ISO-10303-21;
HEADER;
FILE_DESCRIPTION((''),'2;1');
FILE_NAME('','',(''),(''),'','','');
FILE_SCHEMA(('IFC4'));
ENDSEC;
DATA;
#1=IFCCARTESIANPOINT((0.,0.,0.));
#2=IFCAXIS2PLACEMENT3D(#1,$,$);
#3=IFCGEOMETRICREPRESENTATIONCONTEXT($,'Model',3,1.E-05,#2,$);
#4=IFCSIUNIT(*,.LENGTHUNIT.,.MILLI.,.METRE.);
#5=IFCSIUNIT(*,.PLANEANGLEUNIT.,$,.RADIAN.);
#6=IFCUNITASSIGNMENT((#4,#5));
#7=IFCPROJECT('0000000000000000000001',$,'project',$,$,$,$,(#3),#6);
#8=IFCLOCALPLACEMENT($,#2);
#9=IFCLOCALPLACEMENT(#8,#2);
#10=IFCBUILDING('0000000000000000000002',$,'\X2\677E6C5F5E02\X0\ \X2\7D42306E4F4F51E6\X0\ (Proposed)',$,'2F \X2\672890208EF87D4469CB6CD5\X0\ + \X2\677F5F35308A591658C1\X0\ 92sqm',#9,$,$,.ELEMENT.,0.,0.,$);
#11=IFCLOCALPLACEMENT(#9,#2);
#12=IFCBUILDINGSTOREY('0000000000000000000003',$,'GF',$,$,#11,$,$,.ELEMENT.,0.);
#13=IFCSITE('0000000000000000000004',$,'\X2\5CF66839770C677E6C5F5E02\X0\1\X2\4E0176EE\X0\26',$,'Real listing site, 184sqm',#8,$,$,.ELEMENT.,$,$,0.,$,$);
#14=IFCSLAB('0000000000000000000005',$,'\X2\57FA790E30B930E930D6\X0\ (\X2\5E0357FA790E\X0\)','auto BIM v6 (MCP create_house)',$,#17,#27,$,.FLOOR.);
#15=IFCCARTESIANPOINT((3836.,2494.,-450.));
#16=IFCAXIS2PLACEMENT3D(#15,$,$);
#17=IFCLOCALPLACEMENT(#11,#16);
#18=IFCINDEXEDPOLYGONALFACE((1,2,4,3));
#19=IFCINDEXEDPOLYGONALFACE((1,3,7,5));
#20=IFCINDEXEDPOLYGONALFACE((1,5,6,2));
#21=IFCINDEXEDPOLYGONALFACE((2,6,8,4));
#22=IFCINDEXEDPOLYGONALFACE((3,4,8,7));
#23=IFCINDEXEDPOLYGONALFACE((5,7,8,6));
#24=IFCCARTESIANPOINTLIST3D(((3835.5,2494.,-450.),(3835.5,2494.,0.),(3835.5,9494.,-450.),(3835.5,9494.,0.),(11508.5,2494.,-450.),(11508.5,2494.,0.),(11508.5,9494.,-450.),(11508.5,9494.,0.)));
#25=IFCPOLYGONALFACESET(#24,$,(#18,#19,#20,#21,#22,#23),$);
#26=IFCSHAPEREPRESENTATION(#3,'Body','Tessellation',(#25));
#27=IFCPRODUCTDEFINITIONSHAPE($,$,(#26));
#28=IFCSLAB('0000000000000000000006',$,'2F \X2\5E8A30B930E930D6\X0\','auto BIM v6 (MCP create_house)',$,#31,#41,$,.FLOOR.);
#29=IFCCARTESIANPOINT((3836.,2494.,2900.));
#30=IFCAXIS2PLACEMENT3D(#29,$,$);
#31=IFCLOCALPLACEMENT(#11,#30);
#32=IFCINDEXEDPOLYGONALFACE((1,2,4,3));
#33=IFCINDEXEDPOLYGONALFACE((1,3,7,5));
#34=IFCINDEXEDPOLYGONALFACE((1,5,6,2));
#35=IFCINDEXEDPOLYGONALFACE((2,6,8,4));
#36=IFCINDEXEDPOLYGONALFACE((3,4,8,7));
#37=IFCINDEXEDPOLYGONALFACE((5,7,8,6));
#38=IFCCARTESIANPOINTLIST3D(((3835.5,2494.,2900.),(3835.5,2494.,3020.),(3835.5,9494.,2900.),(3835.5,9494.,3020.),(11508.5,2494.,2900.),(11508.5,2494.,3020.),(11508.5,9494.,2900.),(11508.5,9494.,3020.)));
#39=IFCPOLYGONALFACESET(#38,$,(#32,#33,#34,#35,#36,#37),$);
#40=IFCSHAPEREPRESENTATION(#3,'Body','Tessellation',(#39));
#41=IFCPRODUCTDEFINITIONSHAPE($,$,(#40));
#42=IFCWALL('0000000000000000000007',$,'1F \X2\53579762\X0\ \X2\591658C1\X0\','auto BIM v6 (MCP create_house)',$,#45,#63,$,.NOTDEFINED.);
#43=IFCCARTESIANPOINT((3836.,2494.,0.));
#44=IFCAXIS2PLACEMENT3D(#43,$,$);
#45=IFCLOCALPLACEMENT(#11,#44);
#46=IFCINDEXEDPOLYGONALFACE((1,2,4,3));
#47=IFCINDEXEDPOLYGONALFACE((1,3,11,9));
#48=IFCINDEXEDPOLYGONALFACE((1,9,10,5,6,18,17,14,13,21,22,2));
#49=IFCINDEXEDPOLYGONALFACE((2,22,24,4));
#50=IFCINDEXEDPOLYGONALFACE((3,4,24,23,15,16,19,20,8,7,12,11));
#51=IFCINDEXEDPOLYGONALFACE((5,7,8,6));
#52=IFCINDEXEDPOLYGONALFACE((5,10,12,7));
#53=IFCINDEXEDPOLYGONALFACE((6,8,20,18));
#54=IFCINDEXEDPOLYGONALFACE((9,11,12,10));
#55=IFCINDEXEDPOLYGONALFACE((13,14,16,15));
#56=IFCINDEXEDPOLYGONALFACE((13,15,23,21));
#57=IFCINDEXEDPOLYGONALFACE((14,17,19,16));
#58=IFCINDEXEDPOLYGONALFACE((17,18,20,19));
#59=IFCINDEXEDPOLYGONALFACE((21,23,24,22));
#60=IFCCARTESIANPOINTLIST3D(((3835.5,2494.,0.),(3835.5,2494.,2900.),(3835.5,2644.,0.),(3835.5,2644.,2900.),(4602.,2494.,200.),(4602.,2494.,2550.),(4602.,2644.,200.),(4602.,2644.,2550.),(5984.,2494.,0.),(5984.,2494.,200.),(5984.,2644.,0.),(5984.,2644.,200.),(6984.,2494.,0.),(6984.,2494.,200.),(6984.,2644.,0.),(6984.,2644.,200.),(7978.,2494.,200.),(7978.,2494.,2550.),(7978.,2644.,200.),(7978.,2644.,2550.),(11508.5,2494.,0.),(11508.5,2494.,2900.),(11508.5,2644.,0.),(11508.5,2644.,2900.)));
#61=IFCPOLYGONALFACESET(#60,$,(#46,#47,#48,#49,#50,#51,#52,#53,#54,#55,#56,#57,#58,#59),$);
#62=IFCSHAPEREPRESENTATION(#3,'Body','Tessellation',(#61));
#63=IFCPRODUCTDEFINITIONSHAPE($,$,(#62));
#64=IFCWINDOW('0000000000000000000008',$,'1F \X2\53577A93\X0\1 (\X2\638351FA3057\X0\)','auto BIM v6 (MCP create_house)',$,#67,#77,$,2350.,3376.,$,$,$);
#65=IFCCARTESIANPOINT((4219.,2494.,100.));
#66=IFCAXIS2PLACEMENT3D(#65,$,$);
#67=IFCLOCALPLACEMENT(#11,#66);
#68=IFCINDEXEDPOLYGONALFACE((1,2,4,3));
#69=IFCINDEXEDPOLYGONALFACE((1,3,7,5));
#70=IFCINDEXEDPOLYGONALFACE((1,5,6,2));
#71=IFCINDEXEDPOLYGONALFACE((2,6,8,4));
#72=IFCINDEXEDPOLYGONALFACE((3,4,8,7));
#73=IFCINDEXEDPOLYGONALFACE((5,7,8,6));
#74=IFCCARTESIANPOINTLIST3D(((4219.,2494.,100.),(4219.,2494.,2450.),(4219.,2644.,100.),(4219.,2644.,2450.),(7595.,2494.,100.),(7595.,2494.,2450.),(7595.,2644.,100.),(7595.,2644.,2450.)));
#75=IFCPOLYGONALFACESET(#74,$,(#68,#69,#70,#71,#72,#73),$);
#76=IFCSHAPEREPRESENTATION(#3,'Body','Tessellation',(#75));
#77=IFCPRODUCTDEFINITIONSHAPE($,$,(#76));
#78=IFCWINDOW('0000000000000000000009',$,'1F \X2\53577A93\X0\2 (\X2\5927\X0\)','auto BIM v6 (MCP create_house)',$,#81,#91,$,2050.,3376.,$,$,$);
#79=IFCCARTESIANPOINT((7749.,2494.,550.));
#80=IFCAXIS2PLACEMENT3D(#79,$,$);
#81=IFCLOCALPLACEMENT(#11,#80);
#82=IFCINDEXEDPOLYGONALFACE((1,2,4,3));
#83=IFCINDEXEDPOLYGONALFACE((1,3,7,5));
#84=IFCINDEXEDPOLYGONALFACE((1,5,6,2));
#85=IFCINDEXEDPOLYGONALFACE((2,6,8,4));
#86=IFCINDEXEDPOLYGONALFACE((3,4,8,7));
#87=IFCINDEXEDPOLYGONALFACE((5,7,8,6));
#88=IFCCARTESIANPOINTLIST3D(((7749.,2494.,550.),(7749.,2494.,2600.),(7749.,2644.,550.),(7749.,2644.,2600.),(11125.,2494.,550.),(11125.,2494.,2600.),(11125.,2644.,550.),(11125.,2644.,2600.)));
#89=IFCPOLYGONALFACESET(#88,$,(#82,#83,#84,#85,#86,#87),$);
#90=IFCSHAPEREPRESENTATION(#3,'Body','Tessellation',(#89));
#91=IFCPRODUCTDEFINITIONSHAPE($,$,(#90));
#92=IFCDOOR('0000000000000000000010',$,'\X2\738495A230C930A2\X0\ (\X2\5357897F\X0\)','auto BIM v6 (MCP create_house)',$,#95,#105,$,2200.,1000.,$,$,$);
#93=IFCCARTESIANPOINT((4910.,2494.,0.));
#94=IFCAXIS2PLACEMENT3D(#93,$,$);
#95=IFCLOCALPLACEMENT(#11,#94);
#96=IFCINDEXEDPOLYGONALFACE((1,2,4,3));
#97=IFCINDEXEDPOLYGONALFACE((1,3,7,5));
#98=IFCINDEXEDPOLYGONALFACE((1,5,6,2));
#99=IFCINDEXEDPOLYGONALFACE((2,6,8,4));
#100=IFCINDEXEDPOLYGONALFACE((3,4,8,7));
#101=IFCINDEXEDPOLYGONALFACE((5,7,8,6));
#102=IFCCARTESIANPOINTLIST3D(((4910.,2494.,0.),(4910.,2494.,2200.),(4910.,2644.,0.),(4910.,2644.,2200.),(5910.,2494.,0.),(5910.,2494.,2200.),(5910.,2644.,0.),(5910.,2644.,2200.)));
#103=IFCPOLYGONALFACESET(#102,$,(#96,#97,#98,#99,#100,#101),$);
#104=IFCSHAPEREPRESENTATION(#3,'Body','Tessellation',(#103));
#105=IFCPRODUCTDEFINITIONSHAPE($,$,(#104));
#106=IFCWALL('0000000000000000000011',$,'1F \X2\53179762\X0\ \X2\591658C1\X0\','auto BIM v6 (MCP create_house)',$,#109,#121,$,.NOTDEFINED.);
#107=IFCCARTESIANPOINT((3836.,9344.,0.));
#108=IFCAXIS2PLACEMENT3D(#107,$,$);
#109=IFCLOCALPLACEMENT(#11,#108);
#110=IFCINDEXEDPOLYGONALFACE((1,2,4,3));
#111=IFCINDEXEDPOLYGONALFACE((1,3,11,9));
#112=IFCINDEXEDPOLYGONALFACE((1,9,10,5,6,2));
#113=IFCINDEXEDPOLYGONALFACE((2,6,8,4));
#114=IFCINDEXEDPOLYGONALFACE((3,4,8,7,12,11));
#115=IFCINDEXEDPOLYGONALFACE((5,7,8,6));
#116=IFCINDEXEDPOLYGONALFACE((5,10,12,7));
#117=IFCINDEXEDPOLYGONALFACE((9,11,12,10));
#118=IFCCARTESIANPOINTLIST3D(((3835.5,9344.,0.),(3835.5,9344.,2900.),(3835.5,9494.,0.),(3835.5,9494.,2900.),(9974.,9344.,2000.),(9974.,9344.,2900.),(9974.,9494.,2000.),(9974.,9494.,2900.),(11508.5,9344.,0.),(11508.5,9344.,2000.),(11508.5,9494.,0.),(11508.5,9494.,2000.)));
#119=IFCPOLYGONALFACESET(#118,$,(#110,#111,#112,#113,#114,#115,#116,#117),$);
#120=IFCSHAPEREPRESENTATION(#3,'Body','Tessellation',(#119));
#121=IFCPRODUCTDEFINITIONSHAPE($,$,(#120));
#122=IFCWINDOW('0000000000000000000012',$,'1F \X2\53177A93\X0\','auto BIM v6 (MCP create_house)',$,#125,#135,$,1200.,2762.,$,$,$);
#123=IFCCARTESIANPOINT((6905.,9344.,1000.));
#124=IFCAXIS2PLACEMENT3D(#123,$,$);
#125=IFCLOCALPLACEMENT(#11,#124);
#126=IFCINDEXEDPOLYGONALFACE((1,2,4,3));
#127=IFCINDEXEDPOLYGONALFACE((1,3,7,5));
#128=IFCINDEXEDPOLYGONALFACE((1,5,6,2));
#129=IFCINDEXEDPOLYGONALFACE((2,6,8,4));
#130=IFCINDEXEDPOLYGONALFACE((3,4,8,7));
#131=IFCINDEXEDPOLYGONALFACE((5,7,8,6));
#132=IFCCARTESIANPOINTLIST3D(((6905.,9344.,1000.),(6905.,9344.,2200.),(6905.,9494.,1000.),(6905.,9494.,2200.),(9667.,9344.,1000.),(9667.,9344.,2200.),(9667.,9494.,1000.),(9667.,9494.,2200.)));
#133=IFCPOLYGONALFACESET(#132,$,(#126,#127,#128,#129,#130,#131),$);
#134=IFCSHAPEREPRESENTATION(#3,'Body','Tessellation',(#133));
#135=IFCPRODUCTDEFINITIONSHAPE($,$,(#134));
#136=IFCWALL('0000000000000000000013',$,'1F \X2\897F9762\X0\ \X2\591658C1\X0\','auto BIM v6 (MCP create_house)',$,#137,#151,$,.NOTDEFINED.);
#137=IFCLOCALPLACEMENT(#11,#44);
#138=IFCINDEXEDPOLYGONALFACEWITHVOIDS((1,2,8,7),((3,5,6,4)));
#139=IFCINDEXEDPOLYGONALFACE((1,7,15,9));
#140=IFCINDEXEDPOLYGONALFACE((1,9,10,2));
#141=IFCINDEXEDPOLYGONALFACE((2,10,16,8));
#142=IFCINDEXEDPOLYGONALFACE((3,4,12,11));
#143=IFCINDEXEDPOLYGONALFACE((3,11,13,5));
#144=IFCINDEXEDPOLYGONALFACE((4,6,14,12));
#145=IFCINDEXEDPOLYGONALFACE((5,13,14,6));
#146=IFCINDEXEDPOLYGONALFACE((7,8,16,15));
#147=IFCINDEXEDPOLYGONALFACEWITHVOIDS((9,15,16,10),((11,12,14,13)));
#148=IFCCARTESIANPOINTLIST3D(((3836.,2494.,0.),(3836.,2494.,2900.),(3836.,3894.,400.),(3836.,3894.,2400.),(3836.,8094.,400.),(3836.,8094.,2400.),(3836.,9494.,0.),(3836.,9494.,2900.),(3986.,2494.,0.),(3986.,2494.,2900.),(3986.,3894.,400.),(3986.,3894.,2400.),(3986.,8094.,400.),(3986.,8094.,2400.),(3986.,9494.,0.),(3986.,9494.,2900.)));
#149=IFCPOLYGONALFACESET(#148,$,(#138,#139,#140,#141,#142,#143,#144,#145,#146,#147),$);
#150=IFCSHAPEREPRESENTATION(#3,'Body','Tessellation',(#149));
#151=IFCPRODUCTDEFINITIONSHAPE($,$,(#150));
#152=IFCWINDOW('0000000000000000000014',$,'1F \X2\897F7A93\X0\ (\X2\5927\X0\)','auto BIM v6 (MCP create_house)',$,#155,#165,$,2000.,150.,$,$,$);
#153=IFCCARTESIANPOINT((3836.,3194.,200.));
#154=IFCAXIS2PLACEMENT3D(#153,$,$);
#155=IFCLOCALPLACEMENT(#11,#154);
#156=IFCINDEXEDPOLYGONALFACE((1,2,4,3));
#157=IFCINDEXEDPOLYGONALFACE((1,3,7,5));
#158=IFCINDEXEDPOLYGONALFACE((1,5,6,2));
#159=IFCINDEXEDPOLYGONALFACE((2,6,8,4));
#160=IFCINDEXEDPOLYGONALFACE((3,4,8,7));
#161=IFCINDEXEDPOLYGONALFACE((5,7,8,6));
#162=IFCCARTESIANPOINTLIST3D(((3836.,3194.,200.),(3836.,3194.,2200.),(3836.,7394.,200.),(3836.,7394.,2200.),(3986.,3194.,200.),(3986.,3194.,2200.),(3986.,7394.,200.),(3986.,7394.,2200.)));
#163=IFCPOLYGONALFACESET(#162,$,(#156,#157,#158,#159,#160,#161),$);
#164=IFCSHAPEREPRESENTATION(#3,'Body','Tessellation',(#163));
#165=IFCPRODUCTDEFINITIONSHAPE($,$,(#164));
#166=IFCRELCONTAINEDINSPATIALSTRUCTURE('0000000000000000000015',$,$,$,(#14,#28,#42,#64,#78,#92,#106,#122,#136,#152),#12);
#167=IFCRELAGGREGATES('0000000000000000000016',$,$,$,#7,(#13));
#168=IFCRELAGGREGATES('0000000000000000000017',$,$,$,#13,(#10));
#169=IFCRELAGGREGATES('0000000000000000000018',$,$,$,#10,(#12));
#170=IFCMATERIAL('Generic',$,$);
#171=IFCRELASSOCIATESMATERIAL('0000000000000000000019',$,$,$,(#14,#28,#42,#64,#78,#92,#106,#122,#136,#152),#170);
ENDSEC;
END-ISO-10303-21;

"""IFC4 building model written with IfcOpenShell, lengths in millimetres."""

from ifc_helpers import new_model, si_unit, frame, frame_2d, origin, place, context, project, spatial, rectangle, extrude, material, element, fill, save


model = new_model("IFC4")

# Units and contexts
model_context = context("Model", 3, precision=1e-05, world=origin())
ifc_project = project(units=[si_unit("LENGTHUNIT", "METRE", prefix="MILLI"), si_unit("PLANEANGLEUNIT", "RADIAN")], contexts=[model_context])

# Site, building, storey
site_placement = place(None, origin())
site = spatial("IfcSite", under=ifc_project, at=site_placement, Name="島根県松江市1丁目26", ObjectType="Real listing site, 184sqm", CompositionType="ELEMENT", RefElevation=0.0)
building_placement = place(site_placement, origin())
building = spatial("IfcBuilding", under=site, at=building_placement, Name="松江市 終の住処 (Proposed)", ObjectType="2F 木造軸組構法 + 板張り外壁 92sqm", CompositionType="ELEMENT", ElevationOfRefHeight=0.0, ElevationOfTerrain=0.0)
storey_placement = place(building_placement, origin())
storey = spatial("IfcBuildingStorey", under=building, at=storey_placement, Name="GF", CompositionType="ELEMENT", Elevation=0.0)

# Slabs
ifc_material = material(Name="Generic")
slab_1_placement = place(storey_placement, frame((3836.0, 2494.0, -450.0)))
element("IfcSlab", 1, at=slab_1_placement, inside=storey, material=ifc_material, Name="基礎スラブ (布基礎)", Description="auto BIM v6 (MCP create_house)", PredefinedType="FLOOR", context=model_context, shape_type="SweptSolid", body=[
    extrude(rectangle(XDim=7673.0, YDim=7000.0, at=frame_2d((3836.0, 3500.0))), frame((3836.0, 2494.0, -450.0)), (0.0, 0.0, 1.0), 450.0),
])
slab_2_placement = place(storey_placement, frame((3836.0, 2494.0, 2900.0)))
element("IfcSlab", 2, at=slab_2_placement, inside=storey, material=ifc_material, Name="2F 床スラブ", Description="auto BIM v6 (MCP create_house)", PredefinedType="FLOOR", context=model_context, shape_type="SweptSolid", body=[
    extrude(rectangle(XDim=7673.0, YDim=7000.0, at=frame_2d((3836.0, 3500.0))), frame((3836.0, 2494.0, 2900.0)), (0.0, 0.0, 1.0), 120.0),
])

# Wall, openings, windows, door
wall_1_placement = place(storey_placement, frame((3836.0, 2494.0, 0.0)))
wall_1 = element("IfcWall", 3, at=wall_1_placement, inside=storey, material=ifc_material, Name="1F 南面 外壁", Description="auto BIM v6 (MCP create_house)", PredefinedType="NOTDEFINED", context=model_context, shape_type="SweptSolid", body=[
    extrude(rectangle(XDim=7673.0, YDim=150.0, at=frame_2d((3836.0, 75.0))), frame((3836.0, 2494.0, 0.0)), (0.0, 0.0, 1.0), 2900.0),
])
opening_1_placement = place(storey_placement, frame((4219.0, 2494.0, 100.0)))
opening_1 = element("IfcOpeningElement", 4, at=opening_1_placement, cuts=wall_1, PredefinedType="NOTDEFINED", context=model_context, shape_type="SweptSolid", body=[
    extrude(rectangle(XDim=3376.0, YDim=150.0, at=frame_2d((1688.0, 75.0))), frame((4219.0, 2494.0, 100.0)), (0.0, 0.0, 1.0), 2350.0),
])
opening_2_placement = place(storey_placement, frame((7749.0, 2494.0, 550.0)))
opening_2 = element("IfcOpeningElement", 5, at=opening_2_placement, cuts=wall_1, PredefinedType="NOTDEFINED", context=model_context, shape_type="SweptSolid", body=[
    extrude(rectangle(XDim=3376.0, YDim=150.0, at=frame_2d((1688.0, 75.0))), frame((7749.0, 2494.0, 550.0)), (0.0, 0.0, 1.0), 2050.0),
])
opening_3_placement = place(storey_placement, frame((4910.0, 2494.0, 0.0)))
opening_3 = element("IfcOpeningElement", 6, at=opening_3_placement, cuts=wall_1, PredefinedType="NOTDEFINED", context=model_context, shape_type="SweptSolid", body=[
    extrude(rectangle(XDim=1000.0, YDim=150.0, at=frame_2d((500.0, 75.0))), frame((4910.0, 2494.0, 0.0)), (0.0, 0.0, 1.0), 2200.0),
])
window_1_placement = place(storey_placement, frame((4219.0, 2494.0, 100.0)))
window_1 = element("IfcWindow", 7, at=window_1_placement, inside=storey, material=ifc_material, Name="1F 南窓1 (掃出し)", Description="auto BIM v6 (MCP create_house)", OverallHeight=2350.0, OverallWidth=3376.0, context=model_context, shape_type="SweptSolid", body=[
    extrude(rectangle(XDim=3376.0, YDim=150.0, at=frame_2d((1688.0, 75.0))), frame((4219.0, 2494.0, 100.0)), (0.0, 0.0, 1.0), 2350.0),
])
fill(opening_1, window_1)
window_2_placement = place(storey_placement, frame((7749.0, 2494.0, 550.0)))
window_2 = element("IfcWindow", 8, at=window_2_placement, inside=storey, material=ifc_material, Name="1F 南窓2 (大)", Description="auto BIM v6 (MCP create_house)", OverallHeight=2050.0, OverallWidth=3376.0, context=model_context, shape_type="SweptSolid", body=[
    extrude(rectangle(XDim=3376.0, YDim=150.0, at=frame_2d((1688.0, 75.0))), frame((7749.0, 2494.0, 550.0)), (0.0, 0.0, 1.0), 2050.0),
])
fill(opening_2, window_2)
door_placement = place(storey_placement, frame((4910.0, 2494.0, 0.0)))
door = element("IfcDoor", 9, at=door_placement, inside=storey, material=ifc_material, Name="玄関ドア (南西)", Description="auto BIM v6 (MCP create_house)", OverallHeight=2200.0, OverallWidth=1000.0, context=model_context, shape_type="SweptSolid", body=[
    extrude(rectangle(XDim=1000.0, YDim=150.0, at=frame_2d((500.0, 75.0))), frame((4910.0, 2494.0, 0.0)), (0.0, 0.0, 1.0), 2200.0),
])
fill(opening_3, door)

# Walls, openings, windows
wall_2_placement = place(storey_placement, frame((3836.0, 9344.0, 0.0)))
wall_2 = element("IfcWall", 10, at=wall_2_placement, inside=storey, material=ifc_material, Name="1F 北面 外壁", Description="auto BIM v6 (MCP create_house)", PredefinedType="NOTDEFINED", context=model_context, shape_type="SweptSolid", body=[
    extrude(rectangle(XDim=7673.0, YDim=150.0, at=frame_2d((3836.0, 75.0))), frame((3836.0, 9344.0, 0.0)), (0.0, 0.0, 1.0), 2900.0),
])
opening_4_placement = place(storey_placement, frame((6905.0, 9344.0, 1000.0)))
opening_4 = element("IfcOpeningElement", 11, at=opening_4_placement, cuts=wall_2, PredefinedType="NOTDEFINED", context=model_context, shape_type="SweptSolid", body=[
    extrude(rectangle(XDim=2762.0, YDim=150.0, at=frame_2d((1381.0, 75.0))), frame((6905.0, 9344.0, 1000.0)), (0.0, 0.0, 1.0), 1200.0),
])
window_3_placement = place(storey_placement, frame((6905.0, 9344.0, 1000.0)))
window_3 = element("IfcWindow", 12, at=window_3_placement, inside=storey, material=ifc_material, Name="1F 北窓", Description="auto BIM v6 (MCP create_house)", OverallHeight=1200.0, OverallWidth=2762.0, context=model_context, shape_type="SweptSolid", body=[
    extrude(rectangle(XDim=2762.0, YDim=150.0, at=frame_2d((1381.0, 75.0))), frame((6905.0, 9344.0, 1000.0)), (0.0, 0.0, 1.0), 1200.0),
])
fill(opening_4, window_3)
wall_3_placement = place(storey_placement, frame((3836.0, 2494.0, 0.0)))
wall_3 = element("IfcWall", 13, at=wall_3_placement, inside=storey, material=ifc_material, Name="1F 西面 外壁", Description="auto BIM v6 (MCP create_house)", PredefinedType="NOTDEFINED", context=model_context, shape_type="SweptSolid", body=[
    extrude(rectangle(XDim=150.0, YDim=7000.0, at=frame_2d((75.0, 3500.0))), frame((3836.0, 2494.0, 0.0)), (0.0, 0.0, 1.0), 2900.0),
])
opening_5_placement = place(storey_placement, frame((3836.0, 3194.0, 200.0)))
opening_5 = element("IfcOpeningElement", 14, at=opening_5_placement, cuts=wall_3, PredefinedType="NOTDEFINED", context=model_context, shape_type="SweptSolid", body=[
    extrude(rectangle(XDim=150.0, YDim=4200.0, at=frame_2d((75.0, 2100.0))), frame((3836.0, 3194.0, 200.0)), (0.0, 0.0, 1.0), 2000.0),
])
window_4_placement = place(storey_placement, frame((3836.0, 3194.0, 200.0)))
window_4 = element("IfcWindow", 15, at=window_4_placement, inside=storey, material=ifc_material, Name="1F 西窓 (大)", Description="auto BIM v6 (MCP create_house)", OverallHeight=2000.0, OverallWidth=150.0, context=model_context, shape_type="SweptSolid", body=[
    extrude(rectangle(XDim=150.0, YDim=4200.0, at=frame_2d((75.0, 2100.0))), frame((3836.0, 3194.0, 200.0)), (0.0, 0.0, 1.0), 2000.0),
])
fill(opening_5, window_4)

save(model, "model.ifc")
